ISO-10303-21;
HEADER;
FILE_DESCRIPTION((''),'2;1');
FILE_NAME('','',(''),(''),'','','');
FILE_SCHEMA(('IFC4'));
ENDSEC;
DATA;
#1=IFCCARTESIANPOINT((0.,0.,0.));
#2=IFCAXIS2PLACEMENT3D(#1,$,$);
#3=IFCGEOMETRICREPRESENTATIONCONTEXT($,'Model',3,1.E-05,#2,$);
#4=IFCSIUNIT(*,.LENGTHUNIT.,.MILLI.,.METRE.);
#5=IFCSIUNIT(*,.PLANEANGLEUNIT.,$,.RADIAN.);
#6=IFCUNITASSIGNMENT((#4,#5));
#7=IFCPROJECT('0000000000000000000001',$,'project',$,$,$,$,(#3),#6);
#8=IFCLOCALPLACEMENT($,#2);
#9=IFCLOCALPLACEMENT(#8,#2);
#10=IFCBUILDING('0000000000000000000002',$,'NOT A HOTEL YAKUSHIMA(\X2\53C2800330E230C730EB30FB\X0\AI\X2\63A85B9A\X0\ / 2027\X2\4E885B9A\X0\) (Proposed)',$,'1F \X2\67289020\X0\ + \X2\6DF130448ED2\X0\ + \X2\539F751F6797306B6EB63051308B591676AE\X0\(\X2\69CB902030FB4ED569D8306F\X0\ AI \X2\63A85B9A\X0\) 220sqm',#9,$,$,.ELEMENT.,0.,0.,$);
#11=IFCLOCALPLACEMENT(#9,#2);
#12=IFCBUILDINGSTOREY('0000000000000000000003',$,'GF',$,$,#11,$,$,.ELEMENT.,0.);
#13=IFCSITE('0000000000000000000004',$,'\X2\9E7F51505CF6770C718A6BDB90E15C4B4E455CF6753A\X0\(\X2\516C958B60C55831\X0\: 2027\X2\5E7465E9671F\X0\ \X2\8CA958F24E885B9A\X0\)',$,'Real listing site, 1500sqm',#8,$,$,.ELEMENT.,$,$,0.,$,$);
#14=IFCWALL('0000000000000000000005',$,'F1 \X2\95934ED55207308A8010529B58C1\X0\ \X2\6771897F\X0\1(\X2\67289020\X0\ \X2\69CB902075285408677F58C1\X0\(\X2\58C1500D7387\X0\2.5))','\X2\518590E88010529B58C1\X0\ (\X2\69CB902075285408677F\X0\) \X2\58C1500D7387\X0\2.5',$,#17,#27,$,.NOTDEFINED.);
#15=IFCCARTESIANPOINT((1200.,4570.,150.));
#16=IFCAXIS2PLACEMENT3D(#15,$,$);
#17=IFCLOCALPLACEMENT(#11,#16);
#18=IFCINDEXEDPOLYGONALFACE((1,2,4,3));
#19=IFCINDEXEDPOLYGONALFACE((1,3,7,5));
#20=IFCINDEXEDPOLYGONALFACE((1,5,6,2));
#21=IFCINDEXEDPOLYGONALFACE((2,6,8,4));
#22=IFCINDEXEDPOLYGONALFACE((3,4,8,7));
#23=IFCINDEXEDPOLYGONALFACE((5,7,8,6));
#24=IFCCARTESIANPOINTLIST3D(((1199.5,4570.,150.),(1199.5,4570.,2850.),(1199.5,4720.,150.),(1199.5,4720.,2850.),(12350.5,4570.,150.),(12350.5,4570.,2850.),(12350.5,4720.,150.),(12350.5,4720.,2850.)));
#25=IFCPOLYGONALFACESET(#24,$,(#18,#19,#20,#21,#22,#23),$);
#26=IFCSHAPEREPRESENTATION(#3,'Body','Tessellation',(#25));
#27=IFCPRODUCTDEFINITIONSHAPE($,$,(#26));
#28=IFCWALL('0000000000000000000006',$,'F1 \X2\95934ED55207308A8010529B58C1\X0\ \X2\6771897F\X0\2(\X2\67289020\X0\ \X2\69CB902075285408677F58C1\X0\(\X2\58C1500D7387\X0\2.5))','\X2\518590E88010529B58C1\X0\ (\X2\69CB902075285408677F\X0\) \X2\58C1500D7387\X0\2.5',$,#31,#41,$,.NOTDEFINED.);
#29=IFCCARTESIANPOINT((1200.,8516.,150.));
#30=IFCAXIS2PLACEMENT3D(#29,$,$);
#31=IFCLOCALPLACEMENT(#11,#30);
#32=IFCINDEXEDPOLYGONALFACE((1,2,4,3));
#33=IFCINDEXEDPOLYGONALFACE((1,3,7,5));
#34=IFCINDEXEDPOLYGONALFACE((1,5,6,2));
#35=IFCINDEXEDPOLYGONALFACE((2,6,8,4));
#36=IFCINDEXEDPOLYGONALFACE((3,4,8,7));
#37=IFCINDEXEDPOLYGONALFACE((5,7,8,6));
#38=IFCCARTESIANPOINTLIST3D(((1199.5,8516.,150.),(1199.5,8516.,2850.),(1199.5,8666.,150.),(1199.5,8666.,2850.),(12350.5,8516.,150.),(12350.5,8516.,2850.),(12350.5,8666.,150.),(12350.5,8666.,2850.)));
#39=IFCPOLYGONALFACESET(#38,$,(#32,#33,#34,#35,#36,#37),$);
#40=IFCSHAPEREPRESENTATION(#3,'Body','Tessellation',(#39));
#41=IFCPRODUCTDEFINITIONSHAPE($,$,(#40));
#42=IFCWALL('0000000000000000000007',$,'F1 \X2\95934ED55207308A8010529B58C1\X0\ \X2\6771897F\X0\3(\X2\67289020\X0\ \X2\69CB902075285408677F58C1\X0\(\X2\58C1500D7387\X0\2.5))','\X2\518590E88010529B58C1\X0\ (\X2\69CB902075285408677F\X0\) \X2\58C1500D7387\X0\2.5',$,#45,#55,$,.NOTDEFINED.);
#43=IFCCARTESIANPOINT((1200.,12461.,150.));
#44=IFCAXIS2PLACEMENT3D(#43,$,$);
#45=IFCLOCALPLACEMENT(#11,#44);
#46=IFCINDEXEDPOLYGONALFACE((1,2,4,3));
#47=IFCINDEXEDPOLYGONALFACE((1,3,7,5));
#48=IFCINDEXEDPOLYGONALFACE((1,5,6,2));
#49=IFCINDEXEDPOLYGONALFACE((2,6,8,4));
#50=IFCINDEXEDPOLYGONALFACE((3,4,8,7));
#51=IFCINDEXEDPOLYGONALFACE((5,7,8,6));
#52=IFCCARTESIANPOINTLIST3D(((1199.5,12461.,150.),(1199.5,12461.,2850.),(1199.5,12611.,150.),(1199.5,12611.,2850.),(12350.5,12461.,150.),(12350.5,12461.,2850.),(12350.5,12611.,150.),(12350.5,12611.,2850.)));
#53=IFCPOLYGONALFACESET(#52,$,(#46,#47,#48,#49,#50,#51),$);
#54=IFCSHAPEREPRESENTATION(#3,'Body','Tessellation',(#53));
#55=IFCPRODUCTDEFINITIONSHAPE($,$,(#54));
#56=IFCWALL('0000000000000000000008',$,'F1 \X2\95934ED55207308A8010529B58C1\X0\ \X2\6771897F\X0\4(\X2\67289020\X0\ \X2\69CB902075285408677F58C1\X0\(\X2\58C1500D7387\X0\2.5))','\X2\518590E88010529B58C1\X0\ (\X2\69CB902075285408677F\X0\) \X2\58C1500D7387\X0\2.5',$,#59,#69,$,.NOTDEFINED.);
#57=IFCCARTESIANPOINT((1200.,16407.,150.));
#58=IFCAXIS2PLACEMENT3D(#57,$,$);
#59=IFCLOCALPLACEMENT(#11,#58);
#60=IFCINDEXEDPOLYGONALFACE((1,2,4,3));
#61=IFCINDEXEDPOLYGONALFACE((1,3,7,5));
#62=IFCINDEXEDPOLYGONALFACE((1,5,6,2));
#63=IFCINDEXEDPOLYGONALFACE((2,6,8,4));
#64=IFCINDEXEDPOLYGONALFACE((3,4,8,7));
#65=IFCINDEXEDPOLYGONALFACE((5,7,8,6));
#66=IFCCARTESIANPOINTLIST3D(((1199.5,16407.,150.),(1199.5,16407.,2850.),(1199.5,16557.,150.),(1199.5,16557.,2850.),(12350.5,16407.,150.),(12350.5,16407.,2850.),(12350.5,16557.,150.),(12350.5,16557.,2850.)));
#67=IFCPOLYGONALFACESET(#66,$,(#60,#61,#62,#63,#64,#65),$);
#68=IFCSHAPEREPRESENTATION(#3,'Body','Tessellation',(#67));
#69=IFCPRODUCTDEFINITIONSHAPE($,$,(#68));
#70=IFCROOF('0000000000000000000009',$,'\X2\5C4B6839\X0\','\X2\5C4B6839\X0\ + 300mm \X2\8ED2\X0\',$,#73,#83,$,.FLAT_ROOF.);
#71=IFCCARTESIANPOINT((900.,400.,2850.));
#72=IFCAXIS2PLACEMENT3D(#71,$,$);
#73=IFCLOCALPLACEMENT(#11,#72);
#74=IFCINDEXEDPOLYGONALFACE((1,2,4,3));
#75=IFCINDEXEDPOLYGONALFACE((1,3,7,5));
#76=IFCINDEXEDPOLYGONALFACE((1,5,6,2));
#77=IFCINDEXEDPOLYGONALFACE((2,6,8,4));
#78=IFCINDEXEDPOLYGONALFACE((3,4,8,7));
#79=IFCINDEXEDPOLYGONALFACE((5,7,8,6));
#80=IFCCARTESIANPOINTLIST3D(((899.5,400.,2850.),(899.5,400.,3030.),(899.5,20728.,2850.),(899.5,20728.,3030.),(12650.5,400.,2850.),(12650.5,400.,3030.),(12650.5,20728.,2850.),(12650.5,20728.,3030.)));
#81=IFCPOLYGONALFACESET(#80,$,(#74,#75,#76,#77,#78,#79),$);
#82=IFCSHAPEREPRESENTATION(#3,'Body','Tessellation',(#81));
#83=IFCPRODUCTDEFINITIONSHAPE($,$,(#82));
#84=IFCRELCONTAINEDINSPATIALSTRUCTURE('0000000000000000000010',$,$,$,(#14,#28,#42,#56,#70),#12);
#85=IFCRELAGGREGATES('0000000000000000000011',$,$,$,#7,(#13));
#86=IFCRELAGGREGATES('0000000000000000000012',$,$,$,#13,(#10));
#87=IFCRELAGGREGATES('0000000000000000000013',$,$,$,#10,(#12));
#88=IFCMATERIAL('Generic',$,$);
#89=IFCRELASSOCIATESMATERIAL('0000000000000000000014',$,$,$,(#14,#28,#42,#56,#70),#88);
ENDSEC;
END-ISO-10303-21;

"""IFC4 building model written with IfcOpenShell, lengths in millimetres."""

from ifc_helpers import new_model, si_unit, frame, frame_2d, origin, place, context, project, spatial, rectangle, extrude, material, element, save


model = new_model("IFC4")

# Units and contexts
model_context = context("Model", 3, precision=1e-05, world=origin())
ifc_project = project(units=[si_unit("LENGTHUNIT", "METRE", prefix="MILLI"), si_unit("PLANEANGLEUNIT", "RADIAN")], contexts=[model_context])

# Site, building, storey
site_placement = place(None, origin())
site = spatial("IfcSite", under=ifc_project, at=site_placement, Name="鹿児島県熊毛郡屋久島町(公開情報: 2027年早期 販売予定)", ObjectType="Real listing site, 1500sqm", CompositionType="ELEMENT", RefElevation=0.0)
building_placement = place(site_placement, origin())
building = spatial("IfcBuilding", under=site, at=building_placement, Name="NOT A HOTEL YAKUSHIMA(参考モデル・AI推定 / 2027予定) (Proposed)", ObjectType="1F 木造 + 深い軒 + 原生林に溶ける外皮(構造・仕様は AI 推定) 220sqm", CompositionType="ELEMENT", ElevationOfRefHeight=0.0, ElevationOfTerrain=0.0)
storey_placement = place(building_placement, origin())
storey = spatial("IfcBuildingStorey", under=building, at=storey_placement, Name="GF", CompositionType="ELEMENT", Elevation=0.0)

# Shared definitions
ifc_material_1 = material(Name="Generic")

# Walls
wall_1_placement = place(storey_placement, frame((1200.0, 4570.0, 150.0)))
element("IfcWall", 1, at=wall_1_placement, inside=storey, material=ifc_material_1, Name="F1 間仕切り耐力壁 東西1(木造 構造用合板壁(壁倍率2.5))", Description="内部耐力壁 (構造用合板) 壁倍率2.5", PredefinedType="NOTDEFINED", context=model_context, shape_type="SweptSolid", body=[
    extrude(rectangle(XDim=11151.0, YDim=150.0, at=frame_2d((5575.0, 75.0))), frame((1200.0, 4570.0, 150.0)), (0.0, 0.0, 1.0), 2700.0),
])
wall_2_placement = place(storey_placement, frame((1200.0, 8516.0, 150.0)))
element("IfcWall", 2, at=wall_2_placement, inside=storey, material=ifc_material_1, Name="F1 間仕切り耐力壁 東西2(木造 構造用合板壁(壁倍率2.5))", Description="内部耐力壁 (構造用合板) 壁倍率2.5", PredefinedType="NOTDEFINED", context=model_context, shape_type="SweptSolid", body=[
    extrude(rectangle(XDim=11151.0, YDim=150.0, at=frame_2d((5575.0, 75.0))), frame((1200.0, 8516.0, 150.0)), (0.0, 0.0, 1.0), 2700.0),
])
wall_3_placement = place(storey_placement, frame((1200.0, 12461.0, 150.0)))
element("IfcWall", 3, at=wall_3_placement, inside=storey, material=ifc_material_1, Name="F1 間仕切り耐力壁 東西3(木造 構造用合板壁(壁倍率2.5))", Description="内部耐力壁 (構造用合板) 壁倍率2.5", PredefinedType="NOTDEFINED", context=model_context, shape_type="SweptSolid", body=[
    extrude(rectangle(XDim=11151.0, YDim=150.0, at=frame_2d((5575.0, 75.0))), frame((1200.0, 12461.0, 150.0)), (0.0, 0.0, 1.0), 2700.0),
])
wall_4_placement = place(storey_placement, frame((1200.0, 16407.0, 150.0)))
element("IfcWall", 4, at=wall_4_placement, inside=storey, material=ifc_material_1, Name="F1 間仕切り耐力壁 東西4(木造 構造用合板壁(壁倍率2.5))", Description="内部耐力壁 (構造用合板) 壁倍率2.5", PredefinedType="NOTDEFINED", context=model_context, shape_type="SweptSolid", body=[
    extrude(rectangle(XDim=11151.0, YDim=150.0, at=frame_2d((5575.0, 75.0))), frame((1200.0, 16407.0, 150.0)), (0.0, 0.0, 1.0), 2700.0),
])

# Roof
roof_placement = place(storey_placement, frame((900.0, 400.0, 2850.0)))
element("IfcRoof", 5, at=roof_placement, inside=storey, material=ifc_material_1, Name="屋根", Description="屋根 + 300mm 軒", PredefinedType="FLAT_ROOF", context=model_context, shape_type="SweptSolid", body=[
    extrude(rectangle(XDim=11751.0, YDim=20328.0, at=frame_2d((5875.0, 10164.0))), frame((900.0, 400.0, 2850.0)), (0.0, 0.0, 1.0), 180.0),
])

save(model, "model.ifc")
